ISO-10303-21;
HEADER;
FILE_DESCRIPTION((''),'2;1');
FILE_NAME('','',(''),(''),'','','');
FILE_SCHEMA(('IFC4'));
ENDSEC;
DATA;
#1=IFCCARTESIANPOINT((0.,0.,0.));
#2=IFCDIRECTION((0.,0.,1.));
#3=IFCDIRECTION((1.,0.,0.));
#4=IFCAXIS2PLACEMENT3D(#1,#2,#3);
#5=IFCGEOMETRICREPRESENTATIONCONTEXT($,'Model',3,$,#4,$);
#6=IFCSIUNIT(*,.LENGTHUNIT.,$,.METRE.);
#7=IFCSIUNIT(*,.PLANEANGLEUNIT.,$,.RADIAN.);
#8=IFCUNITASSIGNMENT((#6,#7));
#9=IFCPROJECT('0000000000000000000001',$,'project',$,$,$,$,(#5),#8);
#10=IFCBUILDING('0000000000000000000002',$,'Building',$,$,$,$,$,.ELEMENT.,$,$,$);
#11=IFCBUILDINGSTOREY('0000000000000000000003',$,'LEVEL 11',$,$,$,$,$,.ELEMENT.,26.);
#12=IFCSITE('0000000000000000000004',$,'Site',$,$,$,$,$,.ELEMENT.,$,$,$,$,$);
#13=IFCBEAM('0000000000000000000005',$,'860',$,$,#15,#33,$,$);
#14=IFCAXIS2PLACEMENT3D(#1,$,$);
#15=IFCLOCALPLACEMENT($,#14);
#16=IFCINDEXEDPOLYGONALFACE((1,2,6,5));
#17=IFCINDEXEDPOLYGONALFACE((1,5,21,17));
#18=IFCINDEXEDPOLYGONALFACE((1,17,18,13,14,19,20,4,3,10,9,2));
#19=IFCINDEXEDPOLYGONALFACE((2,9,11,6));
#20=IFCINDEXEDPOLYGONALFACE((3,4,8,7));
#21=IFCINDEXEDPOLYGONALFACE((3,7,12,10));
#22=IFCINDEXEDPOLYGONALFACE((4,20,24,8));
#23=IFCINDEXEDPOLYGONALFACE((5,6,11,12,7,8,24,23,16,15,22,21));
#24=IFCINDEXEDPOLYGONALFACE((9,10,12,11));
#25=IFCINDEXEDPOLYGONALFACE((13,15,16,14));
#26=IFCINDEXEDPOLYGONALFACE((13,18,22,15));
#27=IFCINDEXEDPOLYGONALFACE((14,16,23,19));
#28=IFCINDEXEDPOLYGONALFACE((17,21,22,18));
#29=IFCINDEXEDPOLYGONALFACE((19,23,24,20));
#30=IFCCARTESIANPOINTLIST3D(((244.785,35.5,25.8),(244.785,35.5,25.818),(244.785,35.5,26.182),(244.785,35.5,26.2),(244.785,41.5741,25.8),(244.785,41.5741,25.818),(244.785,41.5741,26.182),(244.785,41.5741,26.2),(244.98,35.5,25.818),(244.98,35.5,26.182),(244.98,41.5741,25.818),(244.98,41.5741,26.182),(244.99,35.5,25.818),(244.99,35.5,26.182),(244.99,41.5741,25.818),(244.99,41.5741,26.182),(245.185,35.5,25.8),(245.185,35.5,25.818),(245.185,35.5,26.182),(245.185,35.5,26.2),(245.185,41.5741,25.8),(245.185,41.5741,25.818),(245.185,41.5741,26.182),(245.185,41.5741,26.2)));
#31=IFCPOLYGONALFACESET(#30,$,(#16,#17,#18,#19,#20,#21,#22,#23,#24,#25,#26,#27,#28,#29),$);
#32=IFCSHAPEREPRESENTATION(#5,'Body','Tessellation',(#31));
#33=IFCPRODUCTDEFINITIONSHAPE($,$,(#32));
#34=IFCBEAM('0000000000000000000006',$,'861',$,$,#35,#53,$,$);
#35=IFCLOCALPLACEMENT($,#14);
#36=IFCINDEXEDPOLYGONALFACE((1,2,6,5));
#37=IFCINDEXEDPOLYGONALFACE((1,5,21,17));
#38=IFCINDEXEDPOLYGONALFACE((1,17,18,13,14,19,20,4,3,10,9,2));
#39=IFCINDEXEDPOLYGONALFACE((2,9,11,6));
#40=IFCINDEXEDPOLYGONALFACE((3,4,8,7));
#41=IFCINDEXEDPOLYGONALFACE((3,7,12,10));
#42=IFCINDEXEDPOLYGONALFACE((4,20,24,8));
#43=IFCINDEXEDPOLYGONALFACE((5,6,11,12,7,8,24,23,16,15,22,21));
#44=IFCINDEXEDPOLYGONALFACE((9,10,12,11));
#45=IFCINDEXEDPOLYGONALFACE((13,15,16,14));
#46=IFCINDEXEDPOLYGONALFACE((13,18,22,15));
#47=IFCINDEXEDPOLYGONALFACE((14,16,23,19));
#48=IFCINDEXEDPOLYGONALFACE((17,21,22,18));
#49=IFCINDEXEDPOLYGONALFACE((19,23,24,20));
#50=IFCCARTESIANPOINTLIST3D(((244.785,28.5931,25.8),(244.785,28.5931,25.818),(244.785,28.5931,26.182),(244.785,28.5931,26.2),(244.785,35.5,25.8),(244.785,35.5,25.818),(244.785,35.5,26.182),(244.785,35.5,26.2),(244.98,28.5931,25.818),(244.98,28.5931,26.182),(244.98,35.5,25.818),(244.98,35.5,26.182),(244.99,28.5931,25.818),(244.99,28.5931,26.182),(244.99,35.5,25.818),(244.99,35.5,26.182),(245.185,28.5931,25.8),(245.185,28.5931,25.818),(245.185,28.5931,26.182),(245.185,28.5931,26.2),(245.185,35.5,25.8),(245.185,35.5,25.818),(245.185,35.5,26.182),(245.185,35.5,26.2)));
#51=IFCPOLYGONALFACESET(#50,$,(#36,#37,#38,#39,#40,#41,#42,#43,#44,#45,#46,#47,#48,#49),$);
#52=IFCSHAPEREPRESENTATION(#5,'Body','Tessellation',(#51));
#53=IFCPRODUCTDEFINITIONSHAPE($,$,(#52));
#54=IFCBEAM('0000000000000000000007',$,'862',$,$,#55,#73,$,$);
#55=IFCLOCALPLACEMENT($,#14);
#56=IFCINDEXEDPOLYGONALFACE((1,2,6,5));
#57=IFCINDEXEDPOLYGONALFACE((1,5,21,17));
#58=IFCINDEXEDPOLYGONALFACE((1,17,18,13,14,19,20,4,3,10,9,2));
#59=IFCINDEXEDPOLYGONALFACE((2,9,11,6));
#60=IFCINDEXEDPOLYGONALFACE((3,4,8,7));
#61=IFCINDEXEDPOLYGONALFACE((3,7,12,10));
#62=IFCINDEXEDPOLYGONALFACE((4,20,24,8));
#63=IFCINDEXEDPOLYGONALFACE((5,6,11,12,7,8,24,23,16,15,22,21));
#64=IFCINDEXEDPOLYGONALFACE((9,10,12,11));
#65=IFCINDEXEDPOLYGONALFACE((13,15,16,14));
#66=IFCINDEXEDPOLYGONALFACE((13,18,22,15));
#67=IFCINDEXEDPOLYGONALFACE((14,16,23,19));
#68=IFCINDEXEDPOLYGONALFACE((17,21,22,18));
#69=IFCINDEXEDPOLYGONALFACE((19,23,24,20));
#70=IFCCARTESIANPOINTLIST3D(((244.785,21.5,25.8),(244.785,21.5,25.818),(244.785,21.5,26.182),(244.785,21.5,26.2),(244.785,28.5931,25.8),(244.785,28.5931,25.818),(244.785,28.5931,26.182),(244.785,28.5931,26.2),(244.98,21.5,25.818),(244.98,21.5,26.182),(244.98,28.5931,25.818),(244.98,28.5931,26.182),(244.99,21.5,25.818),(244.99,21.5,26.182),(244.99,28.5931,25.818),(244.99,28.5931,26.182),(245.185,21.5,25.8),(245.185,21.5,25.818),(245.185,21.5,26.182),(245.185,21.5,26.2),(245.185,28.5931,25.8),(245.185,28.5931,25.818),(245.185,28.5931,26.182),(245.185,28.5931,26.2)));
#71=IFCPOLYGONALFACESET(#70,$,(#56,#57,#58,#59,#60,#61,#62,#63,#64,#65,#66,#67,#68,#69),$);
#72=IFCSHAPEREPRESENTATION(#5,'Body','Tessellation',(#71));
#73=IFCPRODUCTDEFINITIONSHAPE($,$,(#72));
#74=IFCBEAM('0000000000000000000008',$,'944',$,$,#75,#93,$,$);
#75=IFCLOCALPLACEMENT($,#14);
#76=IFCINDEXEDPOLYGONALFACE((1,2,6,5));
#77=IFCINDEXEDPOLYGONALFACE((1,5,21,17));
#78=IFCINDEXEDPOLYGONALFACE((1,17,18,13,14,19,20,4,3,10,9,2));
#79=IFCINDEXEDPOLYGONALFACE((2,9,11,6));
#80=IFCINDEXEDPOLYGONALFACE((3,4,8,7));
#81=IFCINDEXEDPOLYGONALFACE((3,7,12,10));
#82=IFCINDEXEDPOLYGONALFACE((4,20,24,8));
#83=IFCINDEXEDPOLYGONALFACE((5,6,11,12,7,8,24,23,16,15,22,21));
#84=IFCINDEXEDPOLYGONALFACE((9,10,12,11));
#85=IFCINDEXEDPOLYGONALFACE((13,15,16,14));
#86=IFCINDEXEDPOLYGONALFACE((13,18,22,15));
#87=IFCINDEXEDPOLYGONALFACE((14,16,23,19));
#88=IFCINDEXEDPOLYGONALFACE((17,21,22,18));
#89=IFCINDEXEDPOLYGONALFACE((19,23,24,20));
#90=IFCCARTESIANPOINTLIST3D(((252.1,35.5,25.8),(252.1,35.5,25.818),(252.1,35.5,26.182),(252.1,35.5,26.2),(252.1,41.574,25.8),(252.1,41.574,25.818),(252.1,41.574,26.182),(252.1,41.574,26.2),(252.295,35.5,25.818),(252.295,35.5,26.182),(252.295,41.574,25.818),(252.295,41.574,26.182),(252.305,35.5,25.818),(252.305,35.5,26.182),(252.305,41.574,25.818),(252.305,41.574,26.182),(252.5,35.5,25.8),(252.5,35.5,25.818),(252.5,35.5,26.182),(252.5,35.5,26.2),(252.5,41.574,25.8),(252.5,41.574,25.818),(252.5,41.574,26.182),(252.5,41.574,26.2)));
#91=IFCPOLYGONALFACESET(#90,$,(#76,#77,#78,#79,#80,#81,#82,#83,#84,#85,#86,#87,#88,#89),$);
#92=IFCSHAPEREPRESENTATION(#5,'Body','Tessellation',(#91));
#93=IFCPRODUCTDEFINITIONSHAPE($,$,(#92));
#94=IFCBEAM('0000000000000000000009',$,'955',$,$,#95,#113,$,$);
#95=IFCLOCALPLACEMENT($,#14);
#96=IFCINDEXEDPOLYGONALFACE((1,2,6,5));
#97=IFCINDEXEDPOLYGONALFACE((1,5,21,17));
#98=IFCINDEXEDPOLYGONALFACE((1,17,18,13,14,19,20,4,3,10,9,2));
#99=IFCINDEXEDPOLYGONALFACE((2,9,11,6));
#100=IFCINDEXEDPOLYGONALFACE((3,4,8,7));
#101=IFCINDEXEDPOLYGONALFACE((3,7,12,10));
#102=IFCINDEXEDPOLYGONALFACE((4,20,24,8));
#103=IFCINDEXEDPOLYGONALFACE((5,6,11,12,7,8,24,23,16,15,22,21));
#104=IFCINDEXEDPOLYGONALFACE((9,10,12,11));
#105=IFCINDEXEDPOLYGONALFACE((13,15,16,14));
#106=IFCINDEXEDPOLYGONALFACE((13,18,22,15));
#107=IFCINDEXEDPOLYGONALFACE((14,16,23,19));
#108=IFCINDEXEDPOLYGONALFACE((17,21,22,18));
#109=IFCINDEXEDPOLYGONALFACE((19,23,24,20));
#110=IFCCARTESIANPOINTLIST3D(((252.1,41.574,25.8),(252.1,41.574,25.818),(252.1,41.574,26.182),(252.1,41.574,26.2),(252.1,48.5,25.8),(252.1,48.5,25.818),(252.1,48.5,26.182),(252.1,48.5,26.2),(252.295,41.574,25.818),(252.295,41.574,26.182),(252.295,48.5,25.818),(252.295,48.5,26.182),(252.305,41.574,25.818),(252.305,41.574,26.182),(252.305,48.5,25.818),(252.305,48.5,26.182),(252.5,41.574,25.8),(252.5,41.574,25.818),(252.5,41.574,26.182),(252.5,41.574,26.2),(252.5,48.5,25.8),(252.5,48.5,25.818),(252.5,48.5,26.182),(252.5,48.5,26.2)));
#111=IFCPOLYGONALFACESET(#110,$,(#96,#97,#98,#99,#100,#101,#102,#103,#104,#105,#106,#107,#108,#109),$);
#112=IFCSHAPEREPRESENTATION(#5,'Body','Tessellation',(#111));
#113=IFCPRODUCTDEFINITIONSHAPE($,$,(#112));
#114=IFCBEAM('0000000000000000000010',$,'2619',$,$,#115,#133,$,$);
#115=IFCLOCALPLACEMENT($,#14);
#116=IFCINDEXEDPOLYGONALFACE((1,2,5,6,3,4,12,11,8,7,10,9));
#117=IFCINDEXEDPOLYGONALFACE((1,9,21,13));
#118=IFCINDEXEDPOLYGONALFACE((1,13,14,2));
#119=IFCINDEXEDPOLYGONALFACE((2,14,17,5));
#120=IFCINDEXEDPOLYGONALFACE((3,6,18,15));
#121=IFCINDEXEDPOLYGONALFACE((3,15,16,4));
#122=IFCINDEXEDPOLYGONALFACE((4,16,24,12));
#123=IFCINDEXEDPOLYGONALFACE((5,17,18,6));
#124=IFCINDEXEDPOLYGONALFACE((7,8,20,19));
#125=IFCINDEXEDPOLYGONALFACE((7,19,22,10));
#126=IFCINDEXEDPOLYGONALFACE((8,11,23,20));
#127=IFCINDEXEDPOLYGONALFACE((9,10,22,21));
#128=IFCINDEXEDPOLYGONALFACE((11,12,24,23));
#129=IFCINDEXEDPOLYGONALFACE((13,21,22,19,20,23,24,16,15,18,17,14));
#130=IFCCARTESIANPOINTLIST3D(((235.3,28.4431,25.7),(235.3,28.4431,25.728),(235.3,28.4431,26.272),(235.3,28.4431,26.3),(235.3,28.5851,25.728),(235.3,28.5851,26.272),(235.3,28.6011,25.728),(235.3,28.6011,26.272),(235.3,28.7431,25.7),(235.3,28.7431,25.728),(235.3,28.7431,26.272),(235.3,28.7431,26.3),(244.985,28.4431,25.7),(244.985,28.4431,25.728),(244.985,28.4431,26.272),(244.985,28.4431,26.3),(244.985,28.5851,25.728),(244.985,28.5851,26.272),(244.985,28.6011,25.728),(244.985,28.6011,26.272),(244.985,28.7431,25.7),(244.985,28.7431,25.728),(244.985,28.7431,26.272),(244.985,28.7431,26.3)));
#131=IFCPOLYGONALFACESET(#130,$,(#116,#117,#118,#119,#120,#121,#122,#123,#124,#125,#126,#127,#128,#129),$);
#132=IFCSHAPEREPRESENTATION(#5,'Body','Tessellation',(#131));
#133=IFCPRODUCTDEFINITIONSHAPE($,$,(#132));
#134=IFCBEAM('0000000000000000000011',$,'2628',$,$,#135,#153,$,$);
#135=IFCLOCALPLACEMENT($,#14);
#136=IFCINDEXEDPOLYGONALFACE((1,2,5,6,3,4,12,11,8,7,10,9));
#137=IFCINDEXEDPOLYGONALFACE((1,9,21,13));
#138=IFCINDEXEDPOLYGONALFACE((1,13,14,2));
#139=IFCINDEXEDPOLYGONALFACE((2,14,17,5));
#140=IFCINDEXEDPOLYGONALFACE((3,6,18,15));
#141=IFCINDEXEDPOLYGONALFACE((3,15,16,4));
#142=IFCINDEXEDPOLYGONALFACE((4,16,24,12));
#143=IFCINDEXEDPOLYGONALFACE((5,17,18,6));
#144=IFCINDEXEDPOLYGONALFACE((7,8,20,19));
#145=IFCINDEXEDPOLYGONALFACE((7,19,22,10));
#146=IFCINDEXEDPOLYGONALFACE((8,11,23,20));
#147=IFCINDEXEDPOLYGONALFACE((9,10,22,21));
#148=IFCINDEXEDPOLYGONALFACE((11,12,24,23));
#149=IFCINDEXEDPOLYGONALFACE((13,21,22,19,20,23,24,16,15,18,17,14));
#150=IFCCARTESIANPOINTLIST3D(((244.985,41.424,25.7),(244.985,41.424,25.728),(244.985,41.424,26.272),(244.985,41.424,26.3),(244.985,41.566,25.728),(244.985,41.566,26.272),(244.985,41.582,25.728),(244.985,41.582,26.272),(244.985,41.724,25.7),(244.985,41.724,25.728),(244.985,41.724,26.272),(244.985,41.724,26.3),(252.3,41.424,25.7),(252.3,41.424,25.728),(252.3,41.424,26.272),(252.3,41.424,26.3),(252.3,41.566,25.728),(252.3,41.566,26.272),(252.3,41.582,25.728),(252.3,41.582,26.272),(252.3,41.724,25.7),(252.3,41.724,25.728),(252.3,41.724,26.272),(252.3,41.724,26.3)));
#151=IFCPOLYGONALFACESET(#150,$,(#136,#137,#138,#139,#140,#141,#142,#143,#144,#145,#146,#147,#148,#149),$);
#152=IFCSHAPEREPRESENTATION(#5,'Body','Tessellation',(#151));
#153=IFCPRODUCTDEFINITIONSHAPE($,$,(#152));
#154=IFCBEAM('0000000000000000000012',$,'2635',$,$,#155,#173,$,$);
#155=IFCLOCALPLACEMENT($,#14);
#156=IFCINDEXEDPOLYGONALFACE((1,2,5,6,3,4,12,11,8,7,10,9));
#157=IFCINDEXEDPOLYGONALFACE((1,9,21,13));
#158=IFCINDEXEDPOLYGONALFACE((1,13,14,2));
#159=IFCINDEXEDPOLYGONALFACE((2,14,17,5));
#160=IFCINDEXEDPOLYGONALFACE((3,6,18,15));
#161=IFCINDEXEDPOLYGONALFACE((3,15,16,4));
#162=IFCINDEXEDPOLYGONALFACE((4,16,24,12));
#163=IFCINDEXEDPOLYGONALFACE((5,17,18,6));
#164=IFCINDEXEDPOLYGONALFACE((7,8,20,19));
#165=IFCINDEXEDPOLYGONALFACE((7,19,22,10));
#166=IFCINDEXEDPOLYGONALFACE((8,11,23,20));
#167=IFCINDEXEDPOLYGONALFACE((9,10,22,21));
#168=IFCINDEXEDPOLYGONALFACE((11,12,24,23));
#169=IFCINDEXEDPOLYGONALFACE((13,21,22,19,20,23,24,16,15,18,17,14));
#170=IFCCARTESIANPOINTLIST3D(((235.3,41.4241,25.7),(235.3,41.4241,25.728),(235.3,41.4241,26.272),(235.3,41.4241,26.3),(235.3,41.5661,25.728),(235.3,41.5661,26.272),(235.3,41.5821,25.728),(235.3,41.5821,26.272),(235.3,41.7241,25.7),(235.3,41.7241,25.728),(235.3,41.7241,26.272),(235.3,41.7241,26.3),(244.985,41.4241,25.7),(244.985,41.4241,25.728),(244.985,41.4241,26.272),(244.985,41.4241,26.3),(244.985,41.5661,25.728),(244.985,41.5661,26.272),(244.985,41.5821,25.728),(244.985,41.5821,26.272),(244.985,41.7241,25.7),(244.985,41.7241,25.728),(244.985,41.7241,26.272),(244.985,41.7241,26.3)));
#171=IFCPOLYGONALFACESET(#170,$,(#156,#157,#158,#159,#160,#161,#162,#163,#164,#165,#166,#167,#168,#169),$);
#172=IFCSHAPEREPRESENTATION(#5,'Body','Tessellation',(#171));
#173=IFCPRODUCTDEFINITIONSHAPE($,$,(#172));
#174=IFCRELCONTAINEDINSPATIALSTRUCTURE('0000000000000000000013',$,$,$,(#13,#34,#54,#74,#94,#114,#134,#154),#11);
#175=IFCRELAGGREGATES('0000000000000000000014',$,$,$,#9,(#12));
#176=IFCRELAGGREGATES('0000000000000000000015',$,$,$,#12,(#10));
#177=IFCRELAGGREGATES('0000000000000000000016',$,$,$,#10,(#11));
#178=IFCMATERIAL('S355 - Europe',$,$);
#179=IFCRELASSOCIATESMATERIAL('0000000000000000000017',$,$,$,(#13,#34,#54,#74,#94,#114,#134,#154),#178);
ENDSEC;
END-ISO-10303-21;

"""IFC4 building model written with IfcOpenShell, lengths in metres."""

from ifc_helpers import new_model, si_unit, frame, origin_with_axes, origin_2d_with_axis, place, context, project, spatial, i_section, extrude, material, material_profile, profile_set, profile_usage, element, save


model = new_model("IFC4")

# Units and contexts
model_context = context("Model", 3, world=origin_with_axes())
ifc_project = project(units=[si_unit("LENGTHUNIT", "METRE"), si_unit("PLANEANGLEUNIT", "RADIAN")], contexts=[model_context])

# Site, building, storey
site = spatial("IfcSite", under=ifc_project, Name="Site", CompositionType="ELEMENT")
building = spatial("IfcBuilding", under=site, Name="Building", CompositionType="ELEMENT")
storey = spatial("IfcBuildingStorey", under=building, Name="LEVEL 11", CompositionType="ELEMENT", Elevation=26.0)

# Shared definitions
ifc_material = material(Name="S355 - Europe")

# Beams
ifc_material_profile_1 = material_profile(ifc_material, i_section(OverallWidth=0.4, OverallDepth=0.4, WebThickness=0.01, FlangeThickness=0.018, at=origin_2d_with_axis()))
ifc_profile_set_1 = profile_set([ifc_material_profile_1])
ifc_profile_usage_1 = profile_usage(ifc_profile_set_1, cardinal=10)
beam_1_placement = place(None, frame((244.985, 41.5741, 26.0), z_axis=(0.0, -1.0, 0.0), x_axis=(1.0, 0.0, 0.0)))
element("IfcBeam", 1, at=beam_1_placement, inside=storey, material=ifc_profile_usage_1, Name="860", context=model_context, shape_type="SweptSolid", body=[
    extrude(i_section(OverallWidth=0.4, OverallDepth=0.4, WebThickness=0.01, FlangeThickness=0.018, at=origin_2d_with_axis()), origin_with_axes(), (0.0, 0.0, 1.0), 6.0741),
])
ifc_material_profile_2 = material_profile(ifc_material, i_section(OverallWidth=0.4, OverallDepth=0.4, WebThickness=0.01, FlangeThickness=0.018, at=origin_2d_with_axis()))
ifc_profile_set_2 = profile_set([ifc_material_profile_2])
ifc_profile_usage_2 = profile_usage(ifc_profile_set_2, cardinal=10)
beam_2_placement = place(None, frame((244.985, 35.5, 26.0), z_axis=(0.0, -1.0, 0.0), x_axis=(1.0, 0.0, 0.0)))
element("IfcBeam", 2, at=beam_2_placement, inside=storey, material=ifc_profile_usage_2, Name="861", context=model_context, shape_type="SweptSolid", body=[
    extrude(i_section(OverallWidth=0.4, OverallDepth=0.4, WebThickness=0.01, FlangeThickness=0.018, at=origin_2d_with_axis()), origin_with_axes(), (0.0, 0.0, 1.0), 6.9069),
])
ifc_material_profile_3 = material_profile(ifc_material, i_section(OverallWidth=0.4, OverallDepth=0.4, WebThickness=0.01, FlangeThickness=0.018, at=origin_2d_with_axis()))
ifc_profile_set_3 = profile_set([ifc_material_profile_3])
ifc_profile_usage_3 = profile_usage(ifc_profile_set_3, cardinal=10)
beam_3_placement = place(None, frame((244.985, 28.5931, 26.0), z_axis=(0.0, -1.0, 0.0), x_axis=(1.0, 0.0, 0.0)))
element("IfcBeam", 3, at=beam_3_placement, inside=storey, material=ifc_profile_usage_3, Name="862", context=model_context, shape_type="SweptSolid", body=[
    extrude(i_section(OverallWidth=0.4, OverallDepth=0.4, WebThickness=0.01, FlangeThickness=0.018, at=origin_2d_with_axis()), origin_with_axes(), (0.0, 0.0, 1.0), 7.0931),
])
ifc_material_profile_4 = material_profile(ifc_material, i_section(OverallWidth=0.4, OverallDepth=0.4, WebThickness=0.01, FlangeThickness=0.018, at=origin_2d_with_axis()))
ifc_profile_set_4 = profile_set([ifc_material_profile_4])
ifc_profile_usage_4 = profile_usage(ifc_profile_set_4, cardinal=10)
beam_4_placement = place(None, frame((252.3, 35.5, 26.0), z_axis=(0.0, 1.0, 0.0), x_axis=(-1.0, 0.0, 0.0)))
element("IfcBeam", 4, at=beam_4_placement, inside=storey, material=ifc_profile_usage_4, Name="944", context=model_context, shape_type="SweptSolid", body=[
    extrude(i_section(OverallWidth=0.4, OverallDepth=0.4, WebThickness=0.01, FlangeThickness=0.018, at=origin_2d_with_axis()), origin_with_axes(), (0.0, 0.0, 1.0), 6.074),
])
ifc_material_profile_5 = material_profile(ifc_material, i_section(OverallWidth=0.4, OverallDepth=0.4, WebThickness=0.01, FlangeThickness=0.018, at=origin_2d_with_axis()))
ifc_profile_set_5 = profile_set([ifc_material_profile_5])
ifc_profile_usage_5 = profile_usage(ifc_profile_set_5, cardinal=10)
beam_5_placement = place(None, frame((252.3, 41.574, 26.0), z_axis=(0.0, 1.0, 0.0), x_axis=(-1.0, 0.0, 0.0)))
element("IfcBeam", 5, at=beam_5_placement, inside=storey, material=ifc_profile_usage_5, Name="955", context=model_context, shape_type="SweptSolid", body=[
    extrude(i_section(OverallWidth=0.4, OverallDepth=0.4, WebThickness=0.01, FlangeThickness=0.018, at=origin_2d_with_axis()), origin_with_axes(), (0.0, 0.0, 1.0), 6.926),
])
ifc_material_profile_6 = material_profile(ifc_material, i_section(OverallWidth=0.3, OverallDepth=0.6, WebThickness=0.016, FlangeThickness=0.028, at=origin_2d_with_axis()))
ifc_profile_set_6 = profile_set([ifc_material_profile_6])
ifc_profile_usage_6 = profile_usage(ifc_profile_set_6, cardinal=10)
beam_6_placement = place(None, frame((244.985, 28.5931, 26.0), z_axis=(-1.0, 0.0, 0.0), x_axis=(0.0, -1.0, 0.0)))
element("IfcBeam", 6, at=beam_6_placement, inside=storey, material=ifc_profile_usage_6, Name="2619", context=model_context, shape_type="SweptSolid", body=[
    extrude(i_section(OverallWidth=0.3, OverallDepth=0.6, WebThickness=0.016, FlangeThickness=0.028, at=origin_2d_with_axis()), origin_with_axes(), (0.0, 0.0, 1.0), 9.685),
])
ifc_material_profile_7 = material_profile(ifc_material, i_section(OverallWidth=0.3, OverallDepth=0.6, WebThickness=0.016, FlangeThickness=0.028, at=origin_2d_with_axis()))
ifc_profile_set_7 = profile_set([ifc_material_profile_7])
ifc_profile_usage_7 = profile_usage(ifc_profile_set_7, cardinal=10)
beam_7_placement = place(None, frame((252.3, 41.574, 26.0), z_axis=(-1.0, 0.0, 0.0), x_axis=(0.0, -1.0, 0.0)))
element("IfcBeam", 7, at=beam_7_placement, inside=storey, material=ifc_profile_usage_7, Name="2628", context=model_context, shape_type="SweptSolid", body=[
    extrude(i_section(OverallWidth=0.3, OverallDepth=0.6, WebThickness=0.016, FlangeThickness=0.028, at=origin_2d_with_axis()), origin_with_axes(), (0.0, 0.0, 1.0), 7.315),
])
ifc_material_profile_8 = material_profile(ifc_material, i_section(OverallWidth=0.3, OverallDepth=0.6, WebThickness=0.016, FlangeThickness=0.028, at=origin_2d_with_axis()))
ifc_profile_set_8 = profile_set([ifc_material_profile_8])
ifc_profile_usage_8 = profile_usage(ifc_profile_set_8, cardinal=10)
beam_8_placement = place(None, frame((244.985, 41.5741, 26.0), z_axis=(-1.0, 0.0, 0.0), x_axis=(0.0, -1.0, 0.0)))
element("IfcBeam", 8, at=beam_8_placement, inside=storey, material=ifc_profile_usage_8, Name="2635", context=model_context, shape_type="SweptSolid", body=[
    extrude(i_section(OverallWidth=0.3, OverallDepth=0.6, WebThickness=0.016, FlangeThickness=0.028, at=origin_2d_with_axis()), origin_with_axes(), (0.0, 0.0, 1.0), 9.685),
])

save(model, "model.ifc")
